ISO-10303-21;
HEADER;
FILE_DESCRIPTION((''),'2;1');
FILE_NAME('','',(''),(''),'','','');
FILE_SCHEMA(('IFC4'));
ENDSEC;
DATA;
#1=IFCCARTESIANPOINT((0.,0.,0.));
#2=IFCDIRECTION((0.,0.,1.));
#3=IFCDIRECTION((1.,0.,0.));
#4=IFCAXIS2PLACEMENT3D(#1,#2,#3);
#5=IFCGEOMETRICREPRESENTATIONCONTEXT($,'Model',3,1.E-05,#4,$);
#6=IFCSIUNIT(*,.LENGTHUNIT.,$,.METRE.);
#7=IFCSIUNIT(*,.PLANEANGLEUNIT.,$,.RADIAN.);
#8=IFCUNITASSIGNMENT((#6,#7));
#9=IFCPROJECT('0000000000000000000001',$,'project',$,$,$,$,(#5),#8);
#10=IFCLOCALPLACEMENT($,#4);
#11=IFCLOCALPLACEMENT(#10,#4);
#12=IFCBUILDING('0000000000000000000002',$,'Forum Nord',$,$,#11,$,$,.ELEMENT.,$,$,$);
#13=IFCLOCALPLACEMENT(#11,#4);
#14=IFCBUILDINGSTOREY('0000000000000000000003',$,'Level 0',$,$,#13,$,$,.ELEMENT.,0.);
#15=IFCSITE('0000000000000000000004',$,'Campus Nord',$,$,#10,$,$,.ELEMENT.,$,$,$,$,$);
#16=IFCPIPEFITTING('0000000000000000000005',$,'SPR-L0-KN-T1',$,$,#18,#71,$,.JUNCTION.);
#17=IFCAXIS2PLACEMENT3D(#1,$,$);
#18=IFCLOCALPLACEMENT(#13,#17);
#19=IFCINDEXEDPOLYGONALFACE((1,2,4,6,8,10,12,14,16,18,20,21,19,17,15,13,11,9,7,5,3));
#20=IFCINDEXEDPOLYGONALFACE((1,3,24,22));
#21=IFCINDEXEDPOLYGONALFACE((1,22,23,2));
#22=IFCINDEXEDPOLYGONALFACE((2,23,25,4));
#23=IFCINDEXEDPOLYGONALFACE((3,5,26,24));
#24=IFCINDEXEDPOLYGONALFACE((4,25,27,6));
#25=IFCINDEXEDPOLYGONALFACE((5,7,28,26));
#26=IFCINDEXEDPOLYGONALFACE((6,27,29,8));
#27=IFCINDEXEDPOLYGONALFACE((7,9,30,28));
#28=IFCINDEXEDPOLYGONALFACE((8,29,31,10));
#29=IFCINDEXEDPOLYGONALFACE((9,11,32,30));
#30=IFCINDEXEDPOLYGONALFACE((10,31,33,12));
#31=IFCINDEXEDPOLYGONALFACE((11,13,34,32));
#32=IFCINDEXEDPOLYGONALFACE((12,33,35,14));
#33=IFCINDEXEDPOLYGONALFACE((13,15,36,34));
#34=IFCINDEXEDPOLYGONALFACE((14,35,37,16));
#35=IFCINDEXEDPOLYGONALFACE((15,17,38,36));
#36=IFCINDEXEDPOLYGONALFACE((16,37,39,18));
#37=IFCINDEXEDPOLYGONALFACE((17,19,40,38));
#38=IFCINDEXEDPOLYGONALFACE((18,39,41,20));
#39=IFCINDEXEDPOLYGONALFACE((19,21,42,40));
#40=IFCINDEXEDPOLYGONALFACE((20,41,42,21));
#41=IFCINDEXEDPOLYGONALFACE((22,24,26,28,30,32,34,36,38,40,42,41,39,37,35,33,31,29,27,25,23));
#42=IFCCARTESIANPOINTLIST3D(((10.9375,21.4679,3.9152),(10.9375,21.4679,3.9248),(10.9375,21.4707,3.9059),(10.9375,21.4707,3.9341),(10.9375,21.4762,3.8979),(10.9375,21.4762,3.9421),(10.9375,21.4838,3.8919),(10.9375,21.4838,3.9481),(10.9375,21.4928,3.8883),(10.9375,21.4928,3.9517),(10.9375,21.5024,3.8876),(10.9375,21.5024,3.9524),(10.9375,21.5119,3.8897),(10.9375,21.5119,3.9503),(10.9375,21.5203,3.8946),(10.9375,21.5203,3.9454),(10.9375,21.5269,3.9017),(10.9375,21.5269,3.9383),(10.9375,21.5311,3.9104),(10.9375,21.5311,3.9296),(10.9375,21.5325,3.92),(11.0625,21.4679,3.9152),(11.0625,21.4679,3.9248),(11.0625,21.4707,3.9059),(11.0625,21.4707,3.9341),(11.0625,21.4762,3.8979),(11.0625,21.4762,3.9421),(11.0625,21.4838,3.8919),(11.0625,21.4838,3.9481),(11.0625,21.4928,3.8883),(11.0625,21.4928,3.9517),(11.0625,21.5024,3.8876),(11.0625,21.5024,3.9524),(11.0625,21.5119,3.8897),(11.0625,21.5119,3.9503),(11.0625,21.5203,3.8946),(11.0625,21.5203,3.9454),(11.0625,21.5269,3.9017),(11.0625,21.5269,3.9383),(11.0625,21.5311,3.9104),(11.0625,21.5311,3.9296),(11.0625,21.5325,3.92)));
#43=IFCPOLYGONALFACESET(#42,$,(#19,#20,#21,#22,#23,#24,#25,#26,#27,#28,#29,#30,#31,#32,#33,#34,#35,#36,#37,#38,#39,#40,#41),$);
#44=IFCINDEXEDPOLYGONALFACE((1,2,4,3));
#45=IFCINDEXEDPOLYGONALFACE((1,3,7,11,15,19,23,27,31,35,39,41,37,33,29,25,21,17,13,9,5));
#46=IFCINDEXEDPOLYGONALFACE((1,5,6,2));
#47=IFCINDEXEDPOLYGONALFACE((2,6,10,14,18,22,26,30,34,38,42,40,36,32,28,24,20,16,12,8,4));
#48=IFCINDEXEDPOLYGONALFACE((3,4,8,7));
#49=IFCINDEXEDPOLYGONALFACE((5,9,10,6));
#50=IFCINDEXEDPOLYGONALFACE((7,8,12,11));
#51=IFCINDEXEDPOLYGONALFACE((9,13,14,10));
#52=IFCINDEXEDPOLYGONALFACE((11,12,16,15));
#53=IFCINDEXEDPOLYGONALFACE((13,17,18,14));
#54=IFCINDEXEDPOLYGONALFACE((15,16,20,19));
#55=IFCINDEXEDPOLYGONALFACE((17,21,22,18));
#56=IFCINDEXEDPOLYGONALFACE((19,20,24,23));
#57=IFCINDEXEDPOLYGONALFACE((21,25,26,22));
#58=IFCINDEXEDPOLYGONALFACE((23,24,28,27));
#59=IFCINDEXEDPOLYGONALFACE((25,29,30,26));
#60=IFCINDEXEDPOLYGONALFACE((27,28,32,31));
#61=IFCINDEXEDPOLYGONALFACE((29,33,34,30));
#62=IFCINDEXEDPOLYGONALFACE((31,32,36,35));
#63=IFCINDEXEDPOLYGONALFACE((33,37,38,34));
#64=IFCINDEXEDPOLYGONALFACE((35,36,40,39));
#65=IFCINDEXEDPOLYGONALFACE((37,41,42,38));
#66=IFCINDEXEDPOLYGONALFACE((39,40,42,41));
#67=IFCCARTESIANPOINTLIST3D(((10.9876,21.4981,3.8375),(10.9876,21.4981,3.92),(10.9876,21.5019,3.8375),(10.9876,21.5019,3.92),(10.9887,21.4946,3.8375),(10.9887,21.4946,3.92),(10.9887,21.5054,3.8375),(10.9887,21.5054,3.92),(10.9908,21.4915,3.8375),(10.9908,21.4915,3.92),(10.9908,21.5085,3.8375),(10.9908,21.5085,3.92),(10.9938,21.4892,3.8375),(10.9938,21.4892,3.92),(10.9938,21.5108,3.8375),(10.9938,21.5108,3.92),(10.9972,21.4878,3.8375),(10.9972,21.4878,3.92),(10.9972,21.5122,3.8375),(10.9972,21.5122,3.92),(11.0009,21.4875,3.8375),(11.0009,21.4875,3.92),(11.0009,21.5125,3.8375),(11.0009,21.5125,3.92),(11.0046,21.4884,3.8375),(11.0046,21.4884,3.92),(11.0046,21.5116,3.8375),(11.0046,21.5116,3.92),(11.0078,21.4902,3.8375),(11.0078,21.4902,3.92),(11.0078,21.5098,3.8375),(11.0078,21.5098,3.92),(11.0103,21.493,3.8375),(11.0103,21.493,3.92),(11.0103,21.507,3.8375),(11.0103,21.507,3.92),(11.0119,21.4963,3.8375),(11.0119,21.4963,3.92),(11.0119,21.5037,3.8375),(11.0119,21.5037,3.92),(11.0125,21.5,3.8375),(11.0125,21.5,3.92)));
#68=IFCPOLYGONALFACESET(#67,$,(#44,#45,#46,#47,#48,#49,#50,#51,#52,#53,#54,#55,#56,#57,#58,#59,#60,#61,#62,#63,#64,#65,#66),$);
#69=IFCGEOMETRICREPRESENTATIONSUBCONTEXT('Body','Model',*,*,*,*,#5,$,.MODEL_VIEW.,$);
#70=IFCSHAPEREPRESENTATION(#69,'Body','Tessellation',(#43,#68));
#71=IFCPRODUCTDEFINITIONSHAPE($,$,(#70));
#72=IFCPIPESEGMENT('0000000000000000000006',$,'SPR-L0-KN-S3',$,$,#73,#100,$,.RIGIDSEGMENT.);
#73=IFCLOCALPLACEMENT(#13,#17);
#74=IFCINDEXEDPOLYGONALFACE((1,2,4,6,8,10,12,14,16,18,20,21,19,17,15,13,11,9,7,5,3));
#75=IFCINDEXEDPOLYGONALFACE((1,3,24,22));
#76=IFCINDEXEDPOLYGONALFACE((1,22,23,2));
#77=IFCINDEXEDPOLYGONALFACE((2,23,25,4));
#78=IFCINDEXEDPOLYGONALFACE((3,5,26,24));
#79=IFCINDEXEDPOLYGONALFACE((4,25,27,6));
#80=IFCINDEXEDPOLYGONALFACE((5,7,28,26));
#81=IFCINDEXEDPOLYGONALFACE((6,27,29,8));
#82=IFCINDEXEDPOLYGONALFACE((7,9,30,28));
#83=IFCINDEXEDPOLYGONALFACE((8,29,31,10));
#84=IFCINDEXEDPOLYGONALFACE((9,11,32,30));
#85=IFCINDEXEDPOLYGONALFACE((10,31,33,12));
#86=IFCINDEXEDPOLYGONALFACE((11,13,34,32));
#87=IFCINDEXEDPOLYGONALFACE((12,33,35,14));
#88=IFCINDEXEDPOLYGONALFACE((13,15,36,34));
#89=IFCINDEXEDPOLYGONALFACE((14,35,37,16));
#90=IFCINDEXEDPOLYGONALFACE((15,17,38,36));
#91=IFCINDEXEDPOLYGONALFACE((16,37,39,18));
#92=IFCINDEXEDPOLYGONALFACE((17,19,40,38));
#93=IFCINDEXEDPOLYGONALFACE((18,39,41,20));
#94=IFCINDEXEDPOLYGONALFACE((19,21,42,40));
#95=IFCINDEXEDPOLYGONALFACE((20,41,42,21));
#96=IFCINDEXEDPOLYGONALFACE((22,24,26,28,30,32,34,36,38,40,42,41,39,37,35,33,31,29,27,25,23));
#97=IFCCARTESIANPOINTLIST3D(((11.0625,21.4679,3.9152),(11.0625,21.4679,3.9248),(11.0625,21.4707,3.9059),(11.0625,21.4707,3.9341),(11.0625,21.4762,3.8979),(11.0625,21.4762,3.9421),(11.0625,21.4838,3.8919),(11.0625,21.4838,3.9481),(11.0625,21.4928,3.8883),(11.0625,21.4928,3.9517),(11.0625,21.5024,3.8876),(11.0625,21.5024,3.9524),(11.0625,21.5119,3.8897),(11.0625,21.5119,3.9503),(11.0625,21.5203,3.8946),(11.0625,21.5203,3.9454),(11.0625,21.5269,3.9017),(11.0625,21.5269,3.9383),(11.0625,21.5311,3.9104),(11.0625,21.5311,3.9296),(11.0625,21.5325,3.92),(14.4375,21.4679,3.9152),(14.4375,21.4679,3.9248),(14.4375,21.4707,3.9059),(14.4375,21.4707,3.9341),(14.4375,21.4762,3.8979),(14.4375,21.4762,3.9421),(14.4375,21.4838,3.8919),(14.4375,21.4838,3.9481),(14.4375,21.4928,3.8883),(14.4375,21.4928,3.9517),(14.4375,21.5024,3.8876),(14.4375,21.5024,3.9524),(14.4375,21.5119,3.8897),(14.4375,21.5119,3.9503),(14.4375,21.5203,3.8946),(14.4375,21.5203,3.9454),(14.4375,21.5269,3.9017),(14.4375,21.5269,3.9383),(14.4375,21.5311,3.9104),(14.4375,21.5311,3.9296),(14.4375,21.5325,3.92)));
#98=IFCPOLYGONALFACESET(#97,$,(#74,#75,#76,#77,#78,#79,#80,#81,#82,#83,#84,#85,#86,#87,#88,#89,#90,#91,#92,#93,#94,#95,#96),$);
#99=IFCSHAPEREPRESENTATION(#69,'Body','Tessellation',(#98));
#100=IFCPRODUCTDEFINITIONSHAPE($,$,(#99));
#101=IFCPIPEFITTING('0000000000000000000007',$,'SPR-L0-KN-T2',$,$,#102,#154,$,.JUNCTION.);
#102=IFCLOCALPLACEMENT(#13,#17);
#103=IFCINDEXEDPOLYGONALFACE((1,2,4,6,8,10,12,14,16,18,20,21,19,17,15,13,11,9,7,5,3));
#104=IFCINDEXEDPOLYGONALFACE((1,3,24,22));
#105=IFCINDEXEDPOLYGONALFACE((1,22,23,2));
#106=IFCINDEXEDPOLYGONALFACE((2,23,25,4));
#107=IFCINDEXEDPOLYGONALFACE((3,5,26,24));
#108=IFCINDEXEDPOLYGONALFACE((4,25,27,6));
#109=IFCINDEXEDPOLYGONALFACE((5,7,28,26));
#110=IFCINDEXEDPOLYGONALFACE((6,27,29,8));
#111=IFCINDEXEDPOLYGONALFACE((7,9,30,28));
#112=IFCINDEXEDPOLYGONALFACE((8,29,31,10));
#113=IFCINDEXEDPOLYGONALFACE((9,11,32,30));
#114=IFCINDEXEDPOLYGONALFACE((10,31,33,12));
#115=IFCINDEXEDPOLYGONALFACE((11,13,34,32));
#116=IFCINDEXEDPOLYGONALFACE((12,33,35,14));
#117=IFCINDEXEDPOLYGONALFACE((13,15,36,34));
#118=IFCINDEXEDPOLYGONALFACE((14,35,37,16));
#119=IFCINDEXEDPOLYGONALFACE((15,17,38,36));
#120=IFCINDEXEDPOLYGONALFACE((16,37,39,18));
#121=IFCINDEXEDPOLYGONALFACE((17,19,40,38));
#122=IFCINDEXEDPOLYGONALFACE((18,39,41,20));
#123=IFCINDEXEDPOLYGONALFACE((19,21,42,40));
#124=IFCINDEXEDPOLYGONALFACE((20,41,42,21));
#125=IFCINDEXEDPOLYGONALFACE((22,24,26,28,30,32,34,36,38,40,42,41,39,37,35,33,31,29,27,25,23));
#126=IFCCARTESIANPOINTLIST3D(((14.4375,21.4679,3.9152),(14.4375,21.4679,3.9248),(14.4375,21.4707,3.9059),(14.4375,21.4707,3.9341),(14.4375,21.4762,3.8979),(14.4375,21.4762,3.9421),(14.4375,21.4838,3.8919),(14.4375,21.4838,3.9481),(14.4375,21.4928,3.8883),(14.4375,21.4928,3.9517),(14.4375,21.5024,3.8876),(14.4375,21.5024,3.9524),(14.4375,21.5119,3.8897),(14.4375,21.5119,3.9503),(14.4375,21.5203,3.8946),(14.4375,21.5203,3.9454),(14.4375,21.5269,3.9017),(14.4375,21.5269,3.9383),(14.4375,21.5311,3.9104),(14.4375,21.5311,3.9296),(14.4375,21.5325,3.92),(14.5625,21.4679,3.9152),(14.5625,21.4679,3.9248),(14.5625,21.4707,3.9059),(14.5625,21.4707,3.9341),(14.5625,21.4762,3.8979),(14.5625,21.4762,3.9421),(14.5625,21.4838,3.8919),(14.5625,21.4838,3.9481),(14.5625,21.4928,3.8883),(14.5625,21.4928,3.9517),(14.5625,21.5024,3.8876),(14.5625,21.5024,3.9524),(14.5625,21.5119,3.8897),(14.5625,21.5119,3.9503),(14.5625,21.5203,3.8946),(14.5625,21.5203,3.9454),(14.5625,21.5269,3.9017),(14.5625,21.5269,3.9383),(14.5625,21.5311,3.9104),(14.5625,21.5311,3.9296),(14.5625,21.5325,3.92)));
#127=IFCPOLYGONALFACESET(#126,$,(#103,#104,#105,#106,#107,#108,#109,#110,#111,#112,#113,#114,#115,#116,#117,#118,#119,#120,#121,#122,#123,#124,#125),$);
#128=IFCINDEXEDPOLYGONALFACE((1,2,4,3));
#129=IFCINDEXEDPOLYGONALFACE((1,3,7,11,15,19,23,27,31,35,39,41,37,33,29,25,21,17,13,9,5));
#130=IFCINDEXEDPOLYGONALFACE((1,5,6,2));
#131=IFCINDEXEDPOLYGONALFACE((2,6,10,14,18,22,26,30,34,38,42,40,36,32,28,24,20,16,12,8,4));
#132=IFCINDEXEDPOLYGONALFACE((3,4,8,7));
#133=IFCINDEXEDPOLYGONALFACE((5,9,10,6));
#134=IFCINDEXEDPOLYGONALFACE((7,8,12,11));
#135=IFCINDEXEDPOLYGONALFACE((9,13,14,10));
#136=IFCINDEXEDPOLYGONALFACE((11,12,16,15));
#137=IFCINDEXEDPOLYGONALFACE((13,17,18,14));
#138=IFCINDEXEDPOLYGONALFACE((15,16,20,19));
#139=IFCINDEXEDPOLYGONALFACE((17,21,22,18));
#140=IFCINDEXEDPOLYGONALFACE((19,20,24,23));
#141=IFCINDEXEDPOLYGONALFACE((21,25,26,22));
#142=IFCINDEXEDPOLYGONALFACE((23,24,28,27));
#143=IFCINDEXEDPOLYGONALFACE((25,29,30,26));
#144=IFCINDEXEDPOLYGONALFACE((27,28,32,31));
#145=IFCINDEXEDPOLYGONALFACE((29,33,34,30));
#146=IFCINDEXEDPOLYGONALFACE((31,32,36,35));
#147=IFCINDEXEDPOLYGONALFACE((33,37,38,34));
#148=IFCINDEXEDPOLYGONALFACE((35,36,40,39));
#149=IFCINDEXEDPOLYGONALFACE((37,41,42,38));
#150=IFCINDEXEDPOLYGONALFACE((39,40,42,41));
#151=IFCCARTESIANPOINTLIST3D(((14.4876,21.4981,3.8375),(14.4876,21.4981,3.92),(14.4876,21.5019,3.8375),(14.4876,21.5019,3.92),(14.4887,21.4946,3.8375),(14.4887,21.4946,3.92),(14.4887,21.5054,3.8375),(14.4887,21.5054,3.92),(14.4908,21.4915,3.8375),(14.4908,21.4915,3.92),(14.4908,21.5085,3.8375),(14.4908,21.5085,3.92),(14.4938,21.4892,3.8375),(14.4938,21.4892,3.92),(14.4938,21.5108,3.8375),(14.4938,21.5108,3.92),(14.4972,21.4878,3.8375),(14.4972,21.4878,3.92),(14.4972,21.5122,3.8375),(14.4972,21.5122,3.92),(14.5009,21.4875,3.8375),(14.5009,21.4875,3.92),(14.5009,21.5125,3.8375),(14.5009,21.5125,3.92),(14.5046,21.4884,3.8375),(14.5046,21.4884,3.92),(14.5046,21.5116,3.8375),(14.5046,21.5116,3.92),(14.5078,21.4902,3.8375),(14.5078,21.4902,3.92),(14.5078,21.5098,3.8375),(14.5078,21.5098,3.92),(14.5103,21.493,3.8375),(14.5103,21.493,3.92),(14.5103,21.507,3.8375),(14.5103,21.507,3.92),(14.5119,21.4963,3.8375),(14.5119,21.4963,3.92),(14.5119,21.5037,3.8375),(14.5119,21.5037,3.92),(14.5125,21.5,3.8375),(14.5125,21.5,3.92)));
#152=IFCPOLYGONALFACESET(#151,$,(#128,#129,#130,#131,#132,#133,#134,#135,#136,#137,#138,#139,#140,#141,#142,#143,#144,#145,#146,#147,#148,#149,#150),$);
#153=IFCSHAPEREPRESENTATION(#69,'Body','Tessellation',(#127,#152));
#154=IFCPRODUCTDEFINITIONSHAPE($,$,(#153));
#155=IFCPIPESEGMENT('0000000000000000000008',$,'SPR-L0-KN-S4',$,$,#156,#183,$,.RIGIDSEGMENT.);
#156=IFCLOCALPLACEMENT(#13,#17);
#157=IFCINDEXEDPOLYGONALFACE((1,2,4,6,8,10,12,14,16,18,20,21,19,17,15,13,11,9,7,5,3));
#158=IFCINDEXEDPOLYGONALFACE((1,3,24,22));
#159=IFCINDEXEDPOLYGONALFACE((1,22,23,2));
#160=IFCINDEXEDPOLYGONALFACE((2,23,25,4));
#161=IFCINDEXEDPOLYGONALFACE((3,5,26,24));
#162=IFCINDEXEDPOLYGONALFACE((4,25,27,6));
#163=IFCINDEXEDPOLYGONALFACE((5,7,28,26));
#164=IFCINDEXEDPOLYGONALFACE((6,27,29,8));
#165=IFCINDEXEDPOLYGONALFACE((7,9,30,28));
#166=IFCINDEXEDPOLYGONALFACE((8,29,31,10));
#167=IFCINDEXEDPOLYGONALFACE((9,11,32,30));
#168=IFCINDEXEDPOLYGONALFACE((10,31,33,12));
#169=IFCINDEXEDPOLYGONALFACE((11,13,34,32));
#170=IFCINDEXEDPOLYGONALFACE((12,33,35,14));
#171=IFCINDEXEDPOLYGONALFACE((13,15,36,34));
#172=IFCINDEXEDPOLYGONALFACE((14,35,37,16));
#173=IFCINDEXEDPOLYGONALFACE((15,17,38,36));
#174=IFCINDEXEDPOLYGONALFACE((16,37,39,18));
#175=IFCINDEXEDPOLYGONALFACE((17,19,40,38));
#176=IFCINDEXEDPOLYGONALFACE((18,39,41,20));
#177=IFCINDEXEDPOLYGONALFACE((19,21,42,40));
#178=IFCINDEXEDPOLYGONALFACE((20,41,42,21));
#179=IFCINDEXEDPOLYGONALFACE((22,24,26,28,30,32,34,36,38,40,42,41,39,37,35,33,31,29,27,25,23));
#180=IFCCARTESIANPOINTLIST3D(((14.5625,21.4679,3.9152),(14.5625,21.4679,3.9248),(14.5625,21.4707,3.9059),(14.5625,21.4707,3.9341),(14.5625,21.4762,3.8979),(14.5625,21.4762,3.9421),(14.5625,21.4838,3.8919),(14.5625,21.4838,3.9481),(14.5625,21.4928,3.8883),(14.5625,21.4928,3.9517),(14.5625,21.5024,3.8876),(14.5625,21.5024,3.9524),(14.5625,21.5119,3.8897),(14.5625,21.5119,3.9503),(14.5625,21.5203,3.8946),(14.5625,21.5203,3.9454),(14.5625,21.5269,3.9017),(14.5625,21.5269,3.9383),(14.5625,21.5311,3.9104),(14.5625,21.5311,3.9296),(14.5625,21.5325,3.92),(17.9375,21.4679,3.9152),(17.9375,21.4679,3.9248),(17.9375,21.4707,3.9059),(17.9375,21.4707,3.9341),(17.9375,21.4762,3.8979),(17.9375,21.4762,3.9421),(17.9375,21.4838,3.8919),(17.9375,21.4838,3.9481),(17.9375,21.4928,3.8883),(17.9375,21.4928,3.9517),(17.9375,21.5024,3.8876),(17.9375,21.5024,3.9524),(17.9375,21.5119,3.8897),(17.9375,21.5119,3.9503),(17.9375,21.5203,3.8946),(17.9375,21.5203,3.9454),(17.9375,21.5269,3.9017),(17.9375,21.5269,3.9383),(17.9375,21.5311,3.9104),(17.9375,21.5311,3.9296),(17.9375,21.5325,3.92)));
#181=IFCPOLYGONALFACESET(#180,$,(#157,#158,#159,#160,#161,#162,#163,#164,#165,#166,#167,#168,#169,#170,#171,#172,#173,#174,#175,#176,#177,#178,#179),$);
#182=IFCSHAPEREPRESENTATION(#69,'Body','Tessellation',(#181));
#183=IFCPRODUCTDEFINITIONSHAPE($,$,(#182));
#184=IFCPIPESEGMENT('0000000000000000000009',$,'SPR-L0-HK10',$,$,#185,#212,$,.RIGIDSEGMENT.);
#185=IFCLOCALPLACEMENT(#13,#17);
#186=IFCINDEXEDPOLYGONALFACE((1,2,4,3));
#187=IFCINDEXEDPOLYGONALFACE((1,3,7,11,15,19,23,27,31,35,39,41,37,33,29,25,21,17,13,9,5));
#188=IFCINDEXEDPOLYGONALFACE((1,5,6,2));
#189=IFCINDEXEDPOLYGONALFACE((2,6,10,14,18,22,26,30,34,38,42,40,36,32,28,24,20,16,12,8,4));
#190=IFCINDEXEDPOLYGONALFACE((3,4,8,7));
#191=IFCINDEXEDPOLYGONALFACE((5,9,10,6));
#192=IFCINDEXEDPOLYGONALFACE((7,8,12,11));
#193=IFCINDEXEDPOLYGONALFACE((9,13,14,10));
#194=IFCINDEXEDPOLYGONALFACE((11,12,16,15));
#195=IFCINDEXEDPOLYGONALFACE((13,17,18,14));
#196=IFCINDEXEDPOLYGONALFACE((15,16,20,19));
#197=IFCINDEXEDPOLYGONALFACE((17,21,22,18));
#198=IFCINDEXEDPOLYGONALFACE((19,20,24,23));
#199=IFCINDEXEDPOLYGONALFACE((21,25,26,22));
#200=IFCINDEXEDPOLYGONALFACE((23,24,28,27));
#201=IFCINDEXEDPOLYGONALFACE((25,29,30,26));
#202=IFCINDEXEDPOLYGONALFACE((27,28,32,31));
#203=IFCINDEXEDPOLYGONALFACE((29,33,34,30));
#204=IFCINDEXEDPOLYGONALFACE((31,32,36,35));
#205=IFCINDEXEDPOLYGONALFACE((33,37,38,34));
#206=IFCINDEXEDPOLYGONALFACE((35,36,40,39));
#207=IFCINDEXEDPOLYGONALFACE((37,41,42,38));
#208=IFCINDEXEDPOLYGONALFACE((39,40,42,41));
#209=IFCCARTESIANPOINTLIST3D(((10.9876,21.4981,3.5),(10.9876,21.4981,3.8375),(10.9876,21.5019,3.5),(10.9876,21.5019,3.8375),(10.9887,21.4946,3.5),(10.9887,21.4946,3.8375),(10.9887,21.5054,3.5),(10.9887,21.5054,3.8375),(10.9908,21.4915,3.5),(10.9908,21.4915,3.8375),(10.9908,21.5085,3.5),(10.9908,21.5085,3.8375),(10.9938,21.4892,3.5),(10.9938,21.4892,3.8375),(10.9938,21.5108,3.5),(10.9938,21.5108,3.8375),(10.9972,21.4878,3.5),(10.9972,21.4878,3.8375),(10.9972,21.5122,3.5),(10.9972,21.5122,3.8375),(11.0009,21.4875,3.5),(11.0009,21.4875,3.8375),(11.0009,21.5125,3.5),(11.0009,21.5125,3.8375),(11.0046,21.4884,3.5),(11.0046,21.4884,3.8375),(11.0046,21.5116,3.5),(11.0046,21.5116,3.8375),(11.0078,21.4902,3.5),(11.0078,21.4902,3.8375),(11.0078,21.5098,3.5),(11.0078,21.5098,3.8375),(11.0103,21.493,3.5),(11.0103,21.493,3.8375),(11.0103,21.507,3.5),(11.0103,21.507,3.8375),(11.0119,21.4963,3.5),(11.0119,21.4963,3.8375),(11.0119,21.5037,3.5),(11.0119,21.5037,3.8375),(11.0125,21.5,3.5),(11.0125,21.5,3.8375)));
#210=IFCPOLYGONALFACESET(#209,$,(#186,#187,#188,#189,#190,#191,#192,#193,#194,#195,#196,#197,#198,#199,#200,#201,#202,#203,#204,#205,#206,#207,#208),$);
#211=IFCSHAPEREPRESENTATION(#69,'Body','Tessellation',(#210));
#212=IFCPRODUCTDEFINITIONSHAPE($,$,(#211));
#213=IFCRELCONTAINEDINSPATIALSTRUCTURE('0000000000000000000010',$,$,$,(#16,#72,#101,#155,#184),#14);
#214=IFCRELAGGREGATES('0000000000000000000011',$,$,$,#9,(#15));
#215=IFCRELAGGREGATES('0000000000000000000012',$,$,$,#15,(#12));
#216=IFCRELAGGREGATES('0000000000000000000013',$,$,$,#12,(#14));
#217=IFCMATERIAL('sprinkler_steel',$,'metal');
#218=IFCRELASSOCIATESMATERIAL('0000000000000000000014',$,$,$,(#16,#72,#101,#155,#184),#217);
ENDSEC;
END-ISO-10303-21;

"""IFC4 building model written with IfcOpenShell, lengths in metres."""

from ifc_helpers import new_model, si_unit, frame, origin_with_axes, origin_2d_with_axis, place, context, subcontext, project, spatial, circle, extrude, material, element, save


model = new_model("IFC4")

# Units and contexts
model_context = context("Model", 3, precision=1e-05, world=origin_with_axes())
body_context = subcontext(model_context, "Body", "Model", "MODEL_VIEW")
ifc_project = project(units=[si_unit("LENGTHUNIT", "METRE"), si_unit("PLANEANGLEUNIT", "RADIAN")], contexts=[model_context])

# Site, building, storey
site_placement = place(None, origin_with_axes())
site = spatial("IfcSite", under=ifc_project, at=site_placement, Name="Campus Nord", CompositionType="ELEMENT")
building_placement = place(site_placement, origin_with_axes())
building = spatial("IfcBuilding", under=site, at=building_placement, Name="Forum Nord", CompositionType="ELEMENT")
storey_placement = place(building_placement, origin_with_axes())
storey = spatial("IfcBuildingStorey", under=building, at=storey_placement, Name="Level 0", CompositionType="ELEMENT", Elevation=0.0)

# Shared definitions
ifc_material_1 = material(Name="sprinkler_steel", Category="metal")

# Pipe fitting
pipe_fitting_1_placement = place(storey_placement, frame((10.9375, 21.5, 3.92), z_axis=(1.0, 0.0, 0.0), x_axis=(0.0, 1.0, 0.0)))
element("IfcPipeFitting", 1, at=pipe_fitting_1_placement, inside=storey, material=ifc_material_1, Name="SPR-L0-KN-T1", PredefinedType="JUNCTION", context=body_context, shape_type="SweptSolid", body=[
    extrude(circle(Radius=0.0325, at=origin_2d_with_axis()), origin_with_axes(), (0.0, 0.0, 1.0), 0.125),
    extrude(circle(Radius=0.0125, at=origin_2d_with_axis()), frame((0.0, 0.0, 0.0625), z_axis=(0.0, -1.0, 0.0), x_axis=(0.0, 0.0, 1.0)), (0.0, 0.0, 1.0), 0.0825),
])

# Pipe segment
pipe_segment_1_placement = place(storey_placement, frame((11.0625, 21.5, 3.92), z_axis=(1.0, 0.0, 0.0), x_axis=(0.0, 1.0, 0.0)))
element("IfcPipeSegment", 2, at=pipe_segment_1_placement, inside=storey, material=ifc_material_1, Name="SPR-L0-KN-S3", PredefinedType="RIGIDSEGMENT", context=body_context, shape_type="SweptSolid", body=[
    extrude(circle(Radius=0.0325, at=origin_2d_with_axis()), origin_with_axes(), (0.0, 0.0, 1.0), 3.375),
])

# Pipe fitting
pipe_fitting_2_placement = place(storey_placement, frame((14.4375, 21.5, 3.92), z_axis=(1.0, 0.0, 0.0), x_axis=(0.0, 1.0, 0.0)))
element("IfcPipeFitting", 3, at=pipe_fitting_2_placement, inside=storey, material=ifc_material_1, Name="SPR-L0-KN-T2", PredefinedType="JUNCTION", context=body_context, shape_type="SweptSolid", body=[
    extrude(circle(Radius=0.0325, at=origin_2d_with_axis()), origin_with_axes(), (0.0, 0.0, 1.0), 0.125),
    extrude(circle(Radius=0.0125, at=origin_2d_with_axis()), frame((0.0, 0.0, 0.0625), z_axis=(0.0, -1.0, 0.0), x_axis=(0.0, 0.0, 1.0)), (0.0, 0.0, 1.0), 0.0825),
])

# Pipe segments
pipe_segment_2_placement = place(storey_placement, frame((14.5625, 21.5, 3.92), z_axis=(1.0, 0.0, 0.0), x_axis=(0.0, 1.0, 0.0)))
element("IfcPipeSegment", 4, at=pipe_segment_2_placement, inside=storey, material=ifc_material_1, Name="SPR-L0-KN-S4", PredefinedType="RIGIDSEGMENT", context=body_context, shape_type="SweptSolid", body=[
    extrude(circle(Radius=0.0325, at=origin_2d_with_axis()), origin_with_axes(), (0.0, 0.0, 1.0), 3.375),
])
pipe_segment_3_placement = place(storey_placement, frame((11.0, 21.5, 3.8375), z_axis=(0.0, 0.0, -1.0), x_axis=(1.0, 0.0, 0.0)))
element("IfcPipeSegment", 5, at=pipe_segment_3_placement, inside=storey, material=ifc_material_1, Name="SPR-L0-HK10", PredefinedType="RIGIDSEGMENT", context=body_context, shape_type="SweptSolid", body=[
    extrude(circle(Radius=0.0125, at=origin_2d_with_axis()), origin_with_axes(), (0.0, 0.0, 1.0), 0.3375),
])

save(model, "model.ifc")
